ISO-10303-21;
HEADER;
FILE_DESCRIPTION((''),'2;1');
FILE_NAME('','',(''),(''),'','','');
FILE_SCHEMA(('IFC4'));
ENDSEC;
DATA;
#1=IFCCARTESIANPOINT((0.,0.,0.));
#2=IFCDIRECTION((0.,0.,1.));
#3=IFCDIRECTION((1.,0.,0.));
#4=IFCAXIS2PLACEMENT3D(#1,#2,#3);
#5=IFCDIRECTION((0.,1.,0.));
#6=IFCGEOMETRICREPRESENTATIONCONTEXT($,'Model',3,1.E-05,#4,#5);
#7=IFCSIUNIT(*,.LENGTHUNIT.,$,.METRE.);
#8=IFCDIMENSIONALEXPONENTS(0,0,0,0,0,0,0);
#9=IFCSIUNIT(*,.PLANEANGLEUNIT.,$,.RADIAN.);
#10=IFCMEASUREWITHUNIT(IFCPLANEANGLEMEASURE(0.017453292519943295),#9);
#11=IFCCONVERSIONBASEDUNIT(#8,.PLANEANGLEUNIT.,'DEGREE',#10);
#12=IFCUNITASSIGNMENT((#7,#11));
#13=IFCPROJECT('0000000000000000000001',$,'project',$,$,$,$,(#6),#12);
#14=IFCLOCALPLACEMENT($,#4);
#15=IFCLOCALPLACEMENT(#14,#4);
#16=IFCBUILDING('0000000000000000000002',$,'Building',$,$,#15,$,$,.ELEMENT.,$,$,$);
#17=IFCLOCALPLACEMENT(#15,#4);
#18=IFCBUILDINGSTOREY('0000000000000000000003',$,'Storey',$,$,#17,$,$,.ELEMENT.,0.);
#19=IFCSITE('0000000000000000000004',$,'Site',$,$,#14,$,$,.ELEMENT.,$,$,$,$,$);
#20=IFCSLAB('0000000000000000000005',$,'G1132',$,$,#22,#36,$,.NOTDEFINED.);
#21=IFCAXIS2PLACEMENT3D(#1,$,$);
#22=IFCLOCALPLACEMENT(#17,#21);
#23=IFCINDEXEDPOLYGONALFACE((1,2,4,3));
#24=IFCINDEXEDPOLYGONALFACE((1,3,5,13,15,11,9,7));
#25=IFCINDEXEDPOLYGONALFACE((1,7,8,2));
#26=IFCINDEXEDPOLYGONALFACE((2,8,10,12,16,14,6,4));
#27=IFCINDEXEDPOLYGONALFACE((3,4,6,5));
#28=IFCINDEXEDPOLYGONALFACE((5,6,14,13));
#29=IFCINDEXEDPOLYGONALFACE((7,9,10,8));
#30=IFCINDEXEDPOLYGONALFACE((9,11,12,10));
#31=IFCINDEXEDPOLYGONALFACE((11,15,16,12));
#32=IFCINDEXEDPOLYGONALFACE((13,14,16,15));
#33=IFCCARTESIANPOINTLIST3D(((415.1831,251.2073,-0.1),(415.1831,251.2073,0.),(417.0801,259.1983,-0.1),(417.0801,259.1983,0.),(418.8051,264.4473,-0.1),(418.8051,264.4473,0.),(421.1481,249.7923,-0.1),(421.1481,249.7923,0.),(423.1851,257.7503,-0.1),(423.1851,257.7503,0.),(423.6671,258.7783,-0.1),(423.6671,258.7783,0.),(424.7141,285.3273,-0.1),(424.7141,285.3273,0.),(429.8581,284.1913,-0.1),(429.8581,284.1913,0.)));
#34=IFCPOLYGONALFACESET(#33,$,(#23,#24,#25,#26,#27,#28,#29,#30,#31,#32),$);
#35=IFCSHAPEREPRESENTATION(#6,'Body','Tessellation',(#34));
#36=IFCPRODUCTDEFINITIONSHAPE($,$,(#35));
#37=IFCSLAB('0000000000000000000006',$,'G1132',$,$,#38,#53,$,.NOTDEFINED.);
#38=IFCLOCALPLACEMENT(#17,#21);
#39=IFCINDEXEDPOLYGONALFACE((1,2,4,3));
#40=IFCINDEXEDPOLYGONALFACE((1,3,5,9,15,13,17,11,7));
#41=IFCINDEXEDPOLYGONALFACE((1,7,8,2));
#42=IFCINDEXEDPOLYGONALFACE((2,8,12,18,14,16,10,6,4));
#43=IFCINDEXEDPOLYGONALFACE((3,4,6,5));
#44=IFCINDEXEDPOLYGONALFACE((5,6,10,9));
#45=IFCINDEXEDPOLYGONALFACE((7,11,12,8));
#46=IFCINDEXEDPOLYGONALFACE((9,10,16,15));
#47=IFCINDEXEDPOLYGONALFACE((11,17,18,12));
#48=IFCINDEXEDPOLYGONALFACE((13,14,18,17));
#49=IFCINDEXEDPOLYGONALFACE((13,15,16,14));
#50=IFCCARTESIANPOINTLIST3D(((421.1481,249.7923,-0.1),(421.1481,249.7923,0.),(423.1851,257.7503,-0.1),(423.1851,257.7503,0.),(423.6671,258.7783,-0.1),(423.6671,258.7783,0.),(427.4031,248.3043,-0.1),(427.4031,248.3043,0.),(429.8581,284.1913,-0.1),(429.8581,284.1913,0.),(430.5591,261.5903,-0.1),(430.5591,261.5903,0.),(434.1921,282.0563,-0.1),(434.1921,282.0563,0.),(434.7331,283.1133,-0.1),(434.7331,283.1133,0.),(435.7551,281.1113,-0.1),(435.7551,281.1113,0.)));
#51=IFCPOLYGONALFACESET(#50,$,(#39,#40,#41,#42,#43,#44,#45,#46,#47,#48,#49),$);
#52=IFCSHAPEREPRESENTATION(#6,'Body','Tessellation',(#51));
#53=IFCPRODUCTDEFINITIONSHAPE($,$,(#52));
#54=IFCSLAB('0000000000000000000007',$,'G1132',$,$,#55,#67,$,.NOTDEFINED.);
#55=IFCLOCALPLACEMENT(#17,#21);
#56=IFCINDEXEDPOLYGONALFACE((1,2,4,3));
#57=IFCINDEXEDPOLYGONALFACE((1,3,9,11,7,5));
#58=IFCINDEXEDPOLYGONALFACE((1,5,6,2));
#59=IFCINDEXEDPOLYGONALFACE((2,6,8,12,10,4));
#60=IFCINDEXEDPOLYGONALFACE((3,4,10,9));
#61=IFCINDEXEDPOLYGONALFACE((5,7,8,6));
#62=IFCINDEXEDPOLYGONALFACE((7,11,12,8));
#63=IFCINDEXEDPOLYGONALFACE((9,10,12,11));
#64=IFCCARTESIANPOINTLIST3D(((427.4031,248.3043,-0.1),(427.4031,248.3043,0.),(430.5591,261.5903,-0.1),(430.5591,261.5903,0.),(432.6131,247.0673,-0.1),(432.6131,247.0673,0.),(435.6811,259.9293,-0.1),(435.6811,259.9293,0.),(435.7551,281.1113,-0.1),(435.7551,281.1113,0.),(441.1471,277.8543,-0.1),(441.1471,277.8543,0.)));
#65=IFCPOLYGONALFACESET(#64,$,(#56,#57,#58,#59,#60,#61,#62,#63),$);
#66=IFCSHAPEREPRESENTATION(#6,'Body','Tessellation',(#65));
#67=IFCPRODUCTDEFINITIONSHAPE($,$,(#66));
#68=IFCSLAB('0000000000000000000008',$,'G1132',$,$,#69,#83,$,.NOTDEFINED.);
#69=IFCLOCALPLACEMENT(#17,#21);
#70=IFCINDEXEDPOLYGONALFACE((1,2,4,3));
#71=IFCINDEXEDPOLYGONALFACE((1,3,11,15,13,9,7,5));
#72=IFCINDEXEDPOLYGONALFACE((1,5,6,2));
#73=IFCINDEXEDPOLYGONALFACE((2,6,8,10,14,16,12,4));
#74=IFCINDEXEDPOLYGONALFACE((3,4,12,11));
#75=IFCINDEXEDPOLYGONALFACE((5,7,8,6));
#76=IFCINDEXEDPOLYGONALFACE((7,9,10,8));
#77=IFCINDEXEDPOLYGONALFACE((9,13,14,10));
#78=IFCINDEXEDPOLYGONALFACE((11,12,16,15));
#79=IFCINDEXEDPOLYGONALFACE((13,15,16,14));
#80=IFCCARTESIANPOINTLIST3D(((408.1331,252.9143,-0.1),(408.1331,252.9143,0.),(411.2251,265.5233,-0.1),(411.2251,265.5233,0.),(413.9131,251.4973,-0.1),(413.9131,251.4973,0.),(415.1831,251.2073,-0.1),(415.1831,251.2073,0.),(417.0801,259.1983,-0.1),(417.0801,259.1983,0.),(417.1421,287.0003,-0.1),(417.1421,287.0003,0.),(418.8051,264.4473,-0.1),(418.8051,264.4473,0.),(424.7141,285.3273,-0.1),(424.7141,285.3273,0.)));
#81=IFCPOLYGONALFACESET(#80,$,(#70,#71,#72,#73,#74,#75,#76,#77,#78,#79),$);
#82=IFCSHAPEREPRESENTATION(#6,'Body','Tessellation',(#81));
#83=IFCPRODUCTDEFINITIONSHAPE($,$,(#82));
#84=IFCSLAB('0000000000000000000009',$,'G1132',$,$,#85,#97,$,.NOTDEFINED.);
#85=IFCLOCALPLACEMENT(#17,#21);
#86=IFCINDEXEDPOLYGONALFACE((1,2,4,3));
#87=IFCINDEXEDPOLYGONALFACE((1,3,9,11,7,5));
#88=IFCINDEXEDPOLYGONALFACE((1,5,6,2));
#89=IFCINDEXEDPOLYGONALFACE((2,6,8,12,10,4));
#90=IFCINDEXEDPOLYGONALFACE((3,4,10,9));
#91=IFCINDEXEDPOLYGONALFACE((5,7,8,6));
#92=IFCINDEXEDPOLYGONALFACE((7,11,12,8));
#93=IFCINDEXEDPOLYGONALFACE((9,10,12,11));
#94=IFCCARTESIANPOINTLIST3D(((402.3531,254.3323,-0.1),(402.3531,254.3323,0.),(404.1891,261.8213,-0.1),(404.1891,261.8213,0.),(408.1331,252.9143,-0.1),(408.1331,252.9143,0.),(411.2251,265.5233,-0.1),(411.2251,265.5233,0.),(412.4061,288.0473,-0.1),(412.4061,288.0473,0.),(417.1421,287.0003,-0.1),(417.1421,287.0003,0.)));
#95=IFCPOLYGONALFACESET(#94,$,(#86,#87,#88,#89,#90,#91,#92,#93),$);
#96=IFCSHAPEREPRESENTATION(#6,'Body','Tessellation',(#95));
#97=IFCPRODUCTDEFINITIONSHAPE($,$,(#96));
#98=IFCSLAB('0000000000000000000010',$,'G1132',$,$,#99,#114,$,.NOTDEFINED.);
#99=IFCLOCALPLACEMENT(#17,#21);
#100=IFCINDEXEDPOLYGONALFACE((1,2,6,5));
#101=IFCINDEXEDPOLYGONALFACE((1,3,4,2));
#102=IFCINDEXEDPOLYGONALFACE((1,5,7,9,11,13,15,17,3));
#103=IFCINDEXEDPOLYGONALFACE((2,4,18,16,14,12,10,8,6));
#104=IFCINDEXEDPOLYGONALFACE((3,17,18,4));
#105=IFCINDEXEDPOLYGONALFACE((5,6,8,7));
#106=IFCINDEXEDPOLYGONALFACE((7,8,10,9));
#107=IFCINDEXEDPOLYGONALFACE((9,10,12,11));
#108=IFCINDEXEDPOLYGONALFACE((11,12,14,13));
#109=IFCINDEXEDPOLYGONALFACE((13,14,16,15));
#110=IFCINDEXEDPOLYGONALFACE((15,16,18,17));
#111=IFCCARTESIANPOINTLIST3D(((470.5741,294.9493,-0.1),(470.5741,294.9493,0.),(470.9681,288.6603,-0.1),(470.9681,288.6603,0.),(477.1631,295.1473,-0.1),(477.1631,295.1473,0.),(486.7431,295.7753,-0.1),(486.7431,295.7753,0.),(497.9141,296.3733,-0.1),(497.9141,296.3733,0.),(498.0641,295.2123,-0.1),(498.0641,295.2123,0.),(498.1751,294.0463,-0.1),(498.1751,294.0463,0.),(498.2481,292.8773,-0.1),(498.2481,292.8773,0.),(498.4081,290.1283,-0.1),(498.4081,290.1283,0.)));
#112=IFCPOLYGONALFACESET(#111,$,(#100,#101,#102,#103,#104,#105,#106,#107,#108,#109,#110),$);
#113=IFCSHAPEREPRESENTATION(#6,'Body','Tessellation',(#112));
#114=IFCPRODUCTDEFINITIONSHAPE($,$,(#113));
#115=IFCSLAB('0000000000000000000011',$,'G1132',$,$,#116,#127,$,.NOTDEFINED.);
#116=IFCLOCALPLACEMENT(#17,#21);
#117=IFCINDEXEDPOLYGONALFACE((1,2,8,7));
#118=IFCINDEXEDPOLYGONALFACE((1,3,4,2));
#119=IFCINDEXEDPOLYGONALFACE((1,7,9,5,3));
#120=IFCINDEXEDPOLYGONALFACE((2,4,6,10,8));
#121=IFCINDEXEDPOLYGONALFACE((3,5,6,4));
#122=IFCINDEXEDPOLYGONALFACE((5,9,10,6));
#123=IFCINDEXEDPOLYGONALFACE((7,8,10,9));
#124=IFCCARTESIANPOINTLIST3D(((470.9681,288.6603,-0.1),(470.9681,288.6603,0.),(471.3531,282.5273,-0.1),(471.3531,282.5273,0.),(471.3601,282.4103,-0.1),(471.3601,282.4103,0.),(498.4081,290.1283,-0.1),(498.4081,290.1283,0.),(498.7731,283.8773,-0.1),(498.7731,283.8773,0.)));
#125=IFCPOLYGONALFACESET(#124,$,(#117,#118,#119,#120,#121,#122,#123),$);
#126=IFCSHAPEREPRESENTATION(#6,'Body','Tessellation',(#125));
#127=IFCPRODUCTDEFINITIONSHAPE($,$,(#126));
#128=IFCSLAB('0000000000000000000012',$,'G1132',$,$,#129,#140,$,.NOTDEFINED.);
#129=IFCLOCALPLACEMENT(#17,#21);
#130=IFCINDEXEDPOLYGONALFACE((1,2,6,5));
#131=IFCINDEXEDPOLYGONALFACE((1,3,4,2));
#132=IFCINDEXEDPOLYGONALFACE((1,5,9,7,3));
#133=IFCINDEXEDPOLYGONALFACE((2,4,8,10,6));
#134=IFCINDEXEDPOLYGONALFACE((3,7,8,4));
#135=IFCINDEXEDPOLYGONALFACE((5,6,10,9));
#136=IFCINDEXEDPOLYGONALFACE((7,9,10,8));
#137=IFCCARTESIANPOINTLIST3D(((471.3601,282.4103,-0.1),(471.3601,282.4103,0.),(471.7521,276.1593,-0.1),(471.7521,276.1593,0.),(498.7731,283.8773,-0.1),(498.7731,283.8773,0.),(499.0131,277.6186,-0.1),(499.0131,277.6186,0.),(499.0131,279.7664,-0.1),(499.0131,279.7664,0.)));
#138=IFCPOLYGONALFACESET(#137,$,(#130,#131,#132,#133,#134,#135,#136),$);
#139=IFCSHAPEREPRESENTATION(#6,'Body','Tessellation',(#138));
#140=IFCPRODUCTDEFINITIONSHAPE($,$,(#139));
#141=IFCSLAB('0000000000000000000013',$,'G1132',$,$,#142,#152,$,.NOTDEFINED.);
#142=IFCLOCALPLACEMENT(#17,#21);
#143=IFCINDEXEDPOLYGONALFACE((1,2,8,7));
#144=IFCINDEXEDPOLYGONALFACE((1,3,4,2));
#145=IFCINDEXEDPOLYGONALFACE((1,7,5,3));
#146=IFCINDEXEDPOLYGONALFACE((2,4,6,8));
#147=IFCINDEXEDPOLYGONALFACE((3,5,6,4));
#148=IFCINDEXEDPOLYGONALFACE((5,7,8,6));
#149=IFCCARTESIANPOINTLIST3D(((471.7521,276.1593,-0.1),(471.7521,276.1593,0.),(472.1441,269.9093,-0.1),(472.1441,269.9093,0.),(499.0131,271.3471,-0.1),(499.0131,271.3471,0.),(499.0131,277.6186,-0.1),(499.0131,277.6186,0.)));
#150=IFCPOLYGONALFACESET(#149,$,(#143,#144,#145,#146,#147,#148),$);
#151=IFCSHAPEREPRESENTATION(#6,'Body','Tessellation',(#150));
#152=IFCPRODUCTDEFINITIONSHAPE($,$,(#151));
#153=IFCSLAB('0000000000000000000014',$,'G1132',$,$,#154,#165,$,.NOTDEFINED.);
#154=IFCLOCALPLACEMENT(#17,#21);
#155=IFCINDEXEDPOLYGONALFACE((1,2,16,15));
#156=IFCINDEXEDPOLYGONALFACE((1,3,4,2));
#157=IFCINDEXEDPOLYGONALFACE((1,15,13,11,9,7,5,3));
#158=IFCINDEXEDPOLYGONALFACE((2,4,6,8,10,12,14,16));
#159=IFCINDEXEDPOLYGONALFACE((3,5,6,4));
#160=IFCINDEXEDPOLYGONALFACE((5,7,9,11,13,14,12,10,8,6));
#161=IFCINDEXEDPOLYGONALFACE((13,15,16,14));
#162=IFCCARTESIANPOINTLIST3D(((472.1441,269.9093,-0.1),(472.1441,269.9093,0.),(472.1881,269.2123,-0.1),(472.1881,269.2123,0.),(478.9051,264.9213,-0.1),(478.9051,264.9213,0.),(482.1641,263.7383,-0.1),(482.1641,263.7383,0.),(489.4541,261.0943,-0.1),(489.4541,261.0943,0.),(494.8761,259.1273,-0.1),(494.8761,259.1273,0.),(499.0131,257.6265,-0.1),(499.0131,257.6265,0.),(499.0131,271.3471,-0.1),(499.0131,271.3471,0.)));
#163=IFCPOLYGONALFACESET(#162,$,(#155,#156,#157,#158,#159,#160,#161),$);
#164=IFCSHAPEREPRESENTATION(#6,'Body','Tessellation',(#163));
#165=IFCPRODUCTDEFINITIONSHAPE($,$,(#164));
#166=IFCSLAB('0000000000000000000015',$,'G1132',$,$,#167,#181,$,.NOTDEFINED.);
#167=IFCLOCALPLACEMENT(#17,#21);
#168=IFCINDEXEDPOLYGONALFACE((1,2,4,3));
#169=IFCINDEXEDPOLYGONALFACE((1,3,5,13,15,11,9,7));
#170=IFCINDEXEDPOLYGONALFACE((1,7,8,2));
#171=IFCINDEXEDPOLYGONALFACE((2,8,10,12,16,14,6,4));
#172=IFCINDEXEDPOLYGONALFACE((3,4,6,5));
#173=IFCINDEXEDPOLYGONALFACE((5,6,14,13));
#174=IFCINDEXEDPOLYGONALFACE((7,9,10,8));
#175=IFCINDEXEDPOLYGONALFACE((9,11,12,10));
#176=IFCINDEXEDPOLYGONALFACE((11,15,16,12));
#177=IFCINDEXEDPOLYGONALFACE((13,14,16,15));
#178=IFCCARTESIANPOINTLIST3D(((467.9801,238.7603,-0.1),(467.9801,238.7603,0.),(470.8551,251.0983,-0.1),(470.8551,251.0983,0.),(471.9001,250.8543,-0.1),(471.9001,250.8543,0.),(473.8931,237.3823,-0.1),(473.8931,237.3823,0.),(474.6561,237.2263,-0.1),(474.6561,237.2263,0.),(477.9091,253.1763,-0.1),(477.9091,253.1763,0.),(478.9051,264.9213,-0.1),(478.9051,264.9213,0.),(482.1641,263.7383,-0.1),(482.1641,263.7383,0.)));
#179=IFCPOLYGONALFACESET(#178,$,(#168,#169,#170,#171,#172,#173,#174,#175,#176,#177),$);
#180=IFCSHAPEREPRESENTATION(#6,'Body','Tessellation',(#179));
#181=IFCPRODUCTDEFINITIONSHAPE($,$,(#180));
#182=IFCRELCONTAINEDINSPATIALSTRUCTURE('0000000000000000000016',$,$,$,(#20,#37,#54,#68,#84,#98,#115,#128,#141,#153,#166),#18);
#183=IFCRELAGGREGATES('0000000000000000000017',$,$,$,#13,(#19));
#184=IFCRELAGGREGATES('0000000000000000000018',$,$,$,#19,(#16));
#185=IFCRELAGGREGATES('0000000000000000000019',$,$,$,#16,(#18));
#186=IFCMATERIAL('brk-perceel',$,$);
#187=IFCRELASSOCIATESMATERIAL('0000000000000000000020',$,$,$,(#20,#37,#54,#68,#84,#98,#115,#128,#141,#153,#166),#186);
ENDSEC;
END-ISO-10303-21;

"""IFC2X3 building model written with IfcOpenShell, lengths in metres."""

from ifc_helpers import new_model, entity, si_unit, converted_unit, direction, frame, origin_with_axes, place, context, project, spatial, polyline, outline, extrude, material, element, save


model = new_model("IFC2X3")

# Units and contexts
model_context = context("Model", 3, precision=1e-05, world=origin_with_axes(), true_north=direction((0.0, 1.0, 0.0)))
ifc_project = project(units=[si_unit("LENGTHUNIT", "METRE"), converted_unit("PLANEANGLEUNIT", "DEGREE", entity("IfcPlaneAngleMeasure", 0.017453292519943295), si_unit("PLANEANGLEUNIT", "RADIAN"), dimensions=[0, 0, 0, 0, 0, 0, 0])], contexts=[model_context])

# Site, building, storey
site_placement = place(None, origin_with_axes())
site = spatial("IfcSite", under=ifc_project, at=site_placement, Name="Site", CompositionType="ELEMENT")
building_placement = place(site_placement, origin_with_axes())
building = spatial("IfcBuilding", under=site, at=building_placement, Name="Building", CompositionType="ELEMENT")
storey_placement = place(building_placement, origin_with_axes())
storey = spatial("IfcBuildingStorey", under=building, at=storey_placement, Name="Storey", CompositionType="ELEMENT", Elevation=0.0)

# Slabs
ifc_material = material(Name="brk-perceel")
slab_1_placement = place(storey_placement, frame((0.0, 0.0, -0.1), z_axis=(0.0, 0.0, 1.0), x_axis=(1.0, 0.0, 0.0)))
element("IfcSlab", 1, at=slab_1_placement, inside=storey, material=ifc_material, Name="G1132", PredefinedType="NOTDEFINED", context=model_context, shape_type="SweptSolid", body=[
    extrude(outline(polyline([(415.1831, 251.2073), (417.0801, 259.1983), (418.8051, 264.4473), (424.7141, 285.3273), (429.8581, 284.1913), (423.6671, 258.7783), (423.1851, 257.7503), (421.1481, 249.7923), (415.1831, 251.2073)])), origin_with_axes(), (0.0, 0.0, 1.0), 0.1),
])
slab_2_placement = place(storey_placement, frame((0.0, 0.0, -0.1), z_axis=(0.0, 0.0, 1.0), x_axis=(1.0, 0.0, 0.0)))
element("IfcSlab", 2, at=slab_2_placement, inside=storey, material=ifc_material, Name="G1132", PredefinedType="NOTDEFINED", context=model_context, shape_type="SweptSolid", body=[
    extrude(outline(polyline([(423.1851, 257.7503), (423.6671, 258.7783), (429.8581, 284.1913), (434.7331, 283.1133), (434.1921, 282.0563), (435.7551, 281.1113), (430.5591, 261.5903), (427.4031, 248.3043), (421.1481, 249.7923), (423.1851, 257.7503)])), origin_with_axes(), (0.0, 0.0, 1.0), 0.1),
])
slab_3_placement = place(storey_placement, frame((0.0, 0.0, -0.1), z_axis=(0.0, 0.0, 1.0), x_axis=(1.0, 0.0, 0.0)))
element("IfcSlab", 3, at=slab_3_placement, inside=storey, material=ifc_material, Name="G1132", PredefinedType="NOTDEFINED", context=model_context, shape_type="SweptSolid", body=[
    extrude(outline(polyline([(430.5591, 261.5903), (435.7551, 281.1113), (441.1471, 277.8543), (435.6811, 259.9293), (432.6131, 247.0673), (427.4031, 248.3043), (430.5591, 261.5903)])), origin_with_axes(), (0.0, 0.0, 1.0), 0.1),
])
slab_4_placement = place(storey_placement, frame((0.0, 0.0, -0.1), z_axis=(0.0, 0.0, 1.0), x_axis=(1.0, 0.0, 0.0)))
element("IfcSlab", 4, at=slab_4_placement, inside=storey, material=ifc_material, Name="G1132", PredefinedType="NOTDEFINED", context=model_context, shape_type="SweptSolid", body=[
    extrude(outline(polyline([(411.2251, 265.5233), (417.1421, 287.0003), (424.7141, 285.3273), (418.8051, 264.4473), (417.0801, 259.1983), (415.1831, 251.2073), (413.9131, 251.4973), (408.1331, 252.9143), (411.2251, 265.5233)])), origin_with_axes(), (0.0, 0.0, 1.0), 0.1),
])
slab_5_placement = place(storey_placement, frame((0.0, 0.0, -0.1), z_axis=(0.0, 0.0, 1.0), x_axis=(1.0, 0.0, 0.0)))
element("IfcSlab", 5, at=slab_5_placement, inside=storey, material=ifc_material, Name="G1132", PredefinedType="NOTDEFINED", context=model_context, shape_type="SweptSolid", body=[
    extrude(outline(polyline([(404.1891, 261.8213), (412.4061, 288.0473), (417.1421, 287.0003), (411.2251, 265.5233), (408.1331, 252.9143), (402.3531, 254.3323), (404.1891, 261.8213)])), origin_with_axes(), (0.0, 0.0, 1.0), 0.1),
])
slab_6_placement = place(storey_placement, frame((0.0, 0.0, -0.1), z_axis=(0.0, 0.0, 1.0), x_axis=(1.0, 0.0, 0.0)))
element("IfcSlab", 6, at=slab_6_placement, inside=storey, material=ifc_material, Name="G1132", PredefinedType="NOTDEFINED", context=model_context, shape_type="SweptSolid", body=[
    extrude(outline(polyline([(498.4081, 290.1283), (470.9681, 288.6603), (470.5741, 294.9493), (477.1631, 295.1473), (486.7431, 295.7753), (497.9141, 296.3733), (498.0641, 295.2123), (498.1751, 294.0463), (498.2481, 292.8773), (498.4081, 290.1283)])), origin_with_axes(), (0.0, 0.0, 1.0), 0.1),
])
slab_7_placement = place(storey_placement, frame((0.0, 0.0, -0.1), z_axis=(0.0, 0.0, 1.0), x_axis=(1.0, 0.0, 0.0)))
element("IfcSlab", 7, at=slab_7_placement, inside=storey, material=ifc_material, Name="G1132", PredefinedType="NOTDEFINED", context=model_context, shape_type="SweptSolid", body=[
    extrude(outline(polyline([(471.3601, 282.4103), (471.3531, 282.5273), (470.9681, 288.6603), (498.4081, 290.1283), (498.7731, 283.8773), (471.3601, 282.4103)])), origin_with_axes(), (0.0, 0.0, 1.0), 0.1),
])
slab_8_placement = place(storey_placement, frame((0.0, 0.0, -0.1), z_axis=(0.0, 0.0, 1.0), x_axis=(1.0, 0.0, 0.0)))
element("IfcSlab", 8, at=slab_8_placement, inside=storey, material=ifc_material, Name="G1132", PredefinedType="NOTDEFINED", context=model_context, shape_type="SweptSolid", body=[
    extrude(outline(polyline([(471.7521, 276.1593), (471.3601, 282.4103), (498.7731, 283.8773), (499.0131, 279.7664), (499.0131, 277.6186), (471.7521, 276.1593)])), origin_with_axes(), (0.0, 0.0, 1.0), 0.1),
])
slab_9_placement = place(storey_placement, frame((0.0, 0.0, -0.1), z_axis=(0.0, 0.0, 1.0), x_axis=(1.0, 0.0, 0.0)))
element("IfcSlab", 9, at=slab_9_placement, inside=storey, material=ifc_material, Name="G1132", PredefinedType="NOTDEFINED", context=model_context, shape_type="SweptSolid", body=[
    extrude(outline(polyline([(472.1441, 269.9093), (471.7521, 276.1593), (499.0131, 277.6186), (499.0131, 271.3471), (472.1441, 269.9093)])), origin_with_axes(), (0.0, 0.0, 1.0), 0.1),
])
slab_10_placement = place(storey_placement, frame((0.0, 0.0, -0.1), z_axis=(0.0, 0.0, 1.0), x_axis=(1.0, 0.0, 0.0)))
element("IfcSlab", 10, at=slab_10_placement, inside=storey, material=ifc_material, Name="G1132", PredefinedType="NOTDEFINED", context=model_context, shape_type="SweptSolid", body=[
    extrude(outline(polyline([(494.8761, 259.1273), (489.4541, 261.0943), (482.1641, 263.7383), (478.9051, 264.9213), (472.1881, 269.2123), (472.1441, 269.9093), (499.0131, 271.3471), (499.0131, 257.6265), (494.8761, 259.1273)])), origin_with_axes(), (0.0, 0.0, 1.0), 0.1),
])
slab_11_placement = place(storey_placement, frame((0.0, 0.0, -0.1), z_axis=(0.0, 0.0, 1.0), x_axis=(1.0, 0.0, 0.0)))
element("IfcSlab", 11, at=slab_11_placement, inside=storey, material=ifc_material, Name="G1132", PredefinedType="NOTDEFINED", context=model_context, shape_type="SweptSolid", body=[
    extrude(outline(polyline([(473.8931, 237.3823), (467.9801, 238.7603), (470.8551, 251.0983), (471.9001, 250.8543), (478.9051, 264.9213), (482.1641, 263.7383), (477.9091, 253.1763), (474.6561, 237.2263), (473.8931, 237.3823)])), origin_with_axes(), (0.0, 0.0, 1.0), 0.1),
])

save(model, "model.ifc")
